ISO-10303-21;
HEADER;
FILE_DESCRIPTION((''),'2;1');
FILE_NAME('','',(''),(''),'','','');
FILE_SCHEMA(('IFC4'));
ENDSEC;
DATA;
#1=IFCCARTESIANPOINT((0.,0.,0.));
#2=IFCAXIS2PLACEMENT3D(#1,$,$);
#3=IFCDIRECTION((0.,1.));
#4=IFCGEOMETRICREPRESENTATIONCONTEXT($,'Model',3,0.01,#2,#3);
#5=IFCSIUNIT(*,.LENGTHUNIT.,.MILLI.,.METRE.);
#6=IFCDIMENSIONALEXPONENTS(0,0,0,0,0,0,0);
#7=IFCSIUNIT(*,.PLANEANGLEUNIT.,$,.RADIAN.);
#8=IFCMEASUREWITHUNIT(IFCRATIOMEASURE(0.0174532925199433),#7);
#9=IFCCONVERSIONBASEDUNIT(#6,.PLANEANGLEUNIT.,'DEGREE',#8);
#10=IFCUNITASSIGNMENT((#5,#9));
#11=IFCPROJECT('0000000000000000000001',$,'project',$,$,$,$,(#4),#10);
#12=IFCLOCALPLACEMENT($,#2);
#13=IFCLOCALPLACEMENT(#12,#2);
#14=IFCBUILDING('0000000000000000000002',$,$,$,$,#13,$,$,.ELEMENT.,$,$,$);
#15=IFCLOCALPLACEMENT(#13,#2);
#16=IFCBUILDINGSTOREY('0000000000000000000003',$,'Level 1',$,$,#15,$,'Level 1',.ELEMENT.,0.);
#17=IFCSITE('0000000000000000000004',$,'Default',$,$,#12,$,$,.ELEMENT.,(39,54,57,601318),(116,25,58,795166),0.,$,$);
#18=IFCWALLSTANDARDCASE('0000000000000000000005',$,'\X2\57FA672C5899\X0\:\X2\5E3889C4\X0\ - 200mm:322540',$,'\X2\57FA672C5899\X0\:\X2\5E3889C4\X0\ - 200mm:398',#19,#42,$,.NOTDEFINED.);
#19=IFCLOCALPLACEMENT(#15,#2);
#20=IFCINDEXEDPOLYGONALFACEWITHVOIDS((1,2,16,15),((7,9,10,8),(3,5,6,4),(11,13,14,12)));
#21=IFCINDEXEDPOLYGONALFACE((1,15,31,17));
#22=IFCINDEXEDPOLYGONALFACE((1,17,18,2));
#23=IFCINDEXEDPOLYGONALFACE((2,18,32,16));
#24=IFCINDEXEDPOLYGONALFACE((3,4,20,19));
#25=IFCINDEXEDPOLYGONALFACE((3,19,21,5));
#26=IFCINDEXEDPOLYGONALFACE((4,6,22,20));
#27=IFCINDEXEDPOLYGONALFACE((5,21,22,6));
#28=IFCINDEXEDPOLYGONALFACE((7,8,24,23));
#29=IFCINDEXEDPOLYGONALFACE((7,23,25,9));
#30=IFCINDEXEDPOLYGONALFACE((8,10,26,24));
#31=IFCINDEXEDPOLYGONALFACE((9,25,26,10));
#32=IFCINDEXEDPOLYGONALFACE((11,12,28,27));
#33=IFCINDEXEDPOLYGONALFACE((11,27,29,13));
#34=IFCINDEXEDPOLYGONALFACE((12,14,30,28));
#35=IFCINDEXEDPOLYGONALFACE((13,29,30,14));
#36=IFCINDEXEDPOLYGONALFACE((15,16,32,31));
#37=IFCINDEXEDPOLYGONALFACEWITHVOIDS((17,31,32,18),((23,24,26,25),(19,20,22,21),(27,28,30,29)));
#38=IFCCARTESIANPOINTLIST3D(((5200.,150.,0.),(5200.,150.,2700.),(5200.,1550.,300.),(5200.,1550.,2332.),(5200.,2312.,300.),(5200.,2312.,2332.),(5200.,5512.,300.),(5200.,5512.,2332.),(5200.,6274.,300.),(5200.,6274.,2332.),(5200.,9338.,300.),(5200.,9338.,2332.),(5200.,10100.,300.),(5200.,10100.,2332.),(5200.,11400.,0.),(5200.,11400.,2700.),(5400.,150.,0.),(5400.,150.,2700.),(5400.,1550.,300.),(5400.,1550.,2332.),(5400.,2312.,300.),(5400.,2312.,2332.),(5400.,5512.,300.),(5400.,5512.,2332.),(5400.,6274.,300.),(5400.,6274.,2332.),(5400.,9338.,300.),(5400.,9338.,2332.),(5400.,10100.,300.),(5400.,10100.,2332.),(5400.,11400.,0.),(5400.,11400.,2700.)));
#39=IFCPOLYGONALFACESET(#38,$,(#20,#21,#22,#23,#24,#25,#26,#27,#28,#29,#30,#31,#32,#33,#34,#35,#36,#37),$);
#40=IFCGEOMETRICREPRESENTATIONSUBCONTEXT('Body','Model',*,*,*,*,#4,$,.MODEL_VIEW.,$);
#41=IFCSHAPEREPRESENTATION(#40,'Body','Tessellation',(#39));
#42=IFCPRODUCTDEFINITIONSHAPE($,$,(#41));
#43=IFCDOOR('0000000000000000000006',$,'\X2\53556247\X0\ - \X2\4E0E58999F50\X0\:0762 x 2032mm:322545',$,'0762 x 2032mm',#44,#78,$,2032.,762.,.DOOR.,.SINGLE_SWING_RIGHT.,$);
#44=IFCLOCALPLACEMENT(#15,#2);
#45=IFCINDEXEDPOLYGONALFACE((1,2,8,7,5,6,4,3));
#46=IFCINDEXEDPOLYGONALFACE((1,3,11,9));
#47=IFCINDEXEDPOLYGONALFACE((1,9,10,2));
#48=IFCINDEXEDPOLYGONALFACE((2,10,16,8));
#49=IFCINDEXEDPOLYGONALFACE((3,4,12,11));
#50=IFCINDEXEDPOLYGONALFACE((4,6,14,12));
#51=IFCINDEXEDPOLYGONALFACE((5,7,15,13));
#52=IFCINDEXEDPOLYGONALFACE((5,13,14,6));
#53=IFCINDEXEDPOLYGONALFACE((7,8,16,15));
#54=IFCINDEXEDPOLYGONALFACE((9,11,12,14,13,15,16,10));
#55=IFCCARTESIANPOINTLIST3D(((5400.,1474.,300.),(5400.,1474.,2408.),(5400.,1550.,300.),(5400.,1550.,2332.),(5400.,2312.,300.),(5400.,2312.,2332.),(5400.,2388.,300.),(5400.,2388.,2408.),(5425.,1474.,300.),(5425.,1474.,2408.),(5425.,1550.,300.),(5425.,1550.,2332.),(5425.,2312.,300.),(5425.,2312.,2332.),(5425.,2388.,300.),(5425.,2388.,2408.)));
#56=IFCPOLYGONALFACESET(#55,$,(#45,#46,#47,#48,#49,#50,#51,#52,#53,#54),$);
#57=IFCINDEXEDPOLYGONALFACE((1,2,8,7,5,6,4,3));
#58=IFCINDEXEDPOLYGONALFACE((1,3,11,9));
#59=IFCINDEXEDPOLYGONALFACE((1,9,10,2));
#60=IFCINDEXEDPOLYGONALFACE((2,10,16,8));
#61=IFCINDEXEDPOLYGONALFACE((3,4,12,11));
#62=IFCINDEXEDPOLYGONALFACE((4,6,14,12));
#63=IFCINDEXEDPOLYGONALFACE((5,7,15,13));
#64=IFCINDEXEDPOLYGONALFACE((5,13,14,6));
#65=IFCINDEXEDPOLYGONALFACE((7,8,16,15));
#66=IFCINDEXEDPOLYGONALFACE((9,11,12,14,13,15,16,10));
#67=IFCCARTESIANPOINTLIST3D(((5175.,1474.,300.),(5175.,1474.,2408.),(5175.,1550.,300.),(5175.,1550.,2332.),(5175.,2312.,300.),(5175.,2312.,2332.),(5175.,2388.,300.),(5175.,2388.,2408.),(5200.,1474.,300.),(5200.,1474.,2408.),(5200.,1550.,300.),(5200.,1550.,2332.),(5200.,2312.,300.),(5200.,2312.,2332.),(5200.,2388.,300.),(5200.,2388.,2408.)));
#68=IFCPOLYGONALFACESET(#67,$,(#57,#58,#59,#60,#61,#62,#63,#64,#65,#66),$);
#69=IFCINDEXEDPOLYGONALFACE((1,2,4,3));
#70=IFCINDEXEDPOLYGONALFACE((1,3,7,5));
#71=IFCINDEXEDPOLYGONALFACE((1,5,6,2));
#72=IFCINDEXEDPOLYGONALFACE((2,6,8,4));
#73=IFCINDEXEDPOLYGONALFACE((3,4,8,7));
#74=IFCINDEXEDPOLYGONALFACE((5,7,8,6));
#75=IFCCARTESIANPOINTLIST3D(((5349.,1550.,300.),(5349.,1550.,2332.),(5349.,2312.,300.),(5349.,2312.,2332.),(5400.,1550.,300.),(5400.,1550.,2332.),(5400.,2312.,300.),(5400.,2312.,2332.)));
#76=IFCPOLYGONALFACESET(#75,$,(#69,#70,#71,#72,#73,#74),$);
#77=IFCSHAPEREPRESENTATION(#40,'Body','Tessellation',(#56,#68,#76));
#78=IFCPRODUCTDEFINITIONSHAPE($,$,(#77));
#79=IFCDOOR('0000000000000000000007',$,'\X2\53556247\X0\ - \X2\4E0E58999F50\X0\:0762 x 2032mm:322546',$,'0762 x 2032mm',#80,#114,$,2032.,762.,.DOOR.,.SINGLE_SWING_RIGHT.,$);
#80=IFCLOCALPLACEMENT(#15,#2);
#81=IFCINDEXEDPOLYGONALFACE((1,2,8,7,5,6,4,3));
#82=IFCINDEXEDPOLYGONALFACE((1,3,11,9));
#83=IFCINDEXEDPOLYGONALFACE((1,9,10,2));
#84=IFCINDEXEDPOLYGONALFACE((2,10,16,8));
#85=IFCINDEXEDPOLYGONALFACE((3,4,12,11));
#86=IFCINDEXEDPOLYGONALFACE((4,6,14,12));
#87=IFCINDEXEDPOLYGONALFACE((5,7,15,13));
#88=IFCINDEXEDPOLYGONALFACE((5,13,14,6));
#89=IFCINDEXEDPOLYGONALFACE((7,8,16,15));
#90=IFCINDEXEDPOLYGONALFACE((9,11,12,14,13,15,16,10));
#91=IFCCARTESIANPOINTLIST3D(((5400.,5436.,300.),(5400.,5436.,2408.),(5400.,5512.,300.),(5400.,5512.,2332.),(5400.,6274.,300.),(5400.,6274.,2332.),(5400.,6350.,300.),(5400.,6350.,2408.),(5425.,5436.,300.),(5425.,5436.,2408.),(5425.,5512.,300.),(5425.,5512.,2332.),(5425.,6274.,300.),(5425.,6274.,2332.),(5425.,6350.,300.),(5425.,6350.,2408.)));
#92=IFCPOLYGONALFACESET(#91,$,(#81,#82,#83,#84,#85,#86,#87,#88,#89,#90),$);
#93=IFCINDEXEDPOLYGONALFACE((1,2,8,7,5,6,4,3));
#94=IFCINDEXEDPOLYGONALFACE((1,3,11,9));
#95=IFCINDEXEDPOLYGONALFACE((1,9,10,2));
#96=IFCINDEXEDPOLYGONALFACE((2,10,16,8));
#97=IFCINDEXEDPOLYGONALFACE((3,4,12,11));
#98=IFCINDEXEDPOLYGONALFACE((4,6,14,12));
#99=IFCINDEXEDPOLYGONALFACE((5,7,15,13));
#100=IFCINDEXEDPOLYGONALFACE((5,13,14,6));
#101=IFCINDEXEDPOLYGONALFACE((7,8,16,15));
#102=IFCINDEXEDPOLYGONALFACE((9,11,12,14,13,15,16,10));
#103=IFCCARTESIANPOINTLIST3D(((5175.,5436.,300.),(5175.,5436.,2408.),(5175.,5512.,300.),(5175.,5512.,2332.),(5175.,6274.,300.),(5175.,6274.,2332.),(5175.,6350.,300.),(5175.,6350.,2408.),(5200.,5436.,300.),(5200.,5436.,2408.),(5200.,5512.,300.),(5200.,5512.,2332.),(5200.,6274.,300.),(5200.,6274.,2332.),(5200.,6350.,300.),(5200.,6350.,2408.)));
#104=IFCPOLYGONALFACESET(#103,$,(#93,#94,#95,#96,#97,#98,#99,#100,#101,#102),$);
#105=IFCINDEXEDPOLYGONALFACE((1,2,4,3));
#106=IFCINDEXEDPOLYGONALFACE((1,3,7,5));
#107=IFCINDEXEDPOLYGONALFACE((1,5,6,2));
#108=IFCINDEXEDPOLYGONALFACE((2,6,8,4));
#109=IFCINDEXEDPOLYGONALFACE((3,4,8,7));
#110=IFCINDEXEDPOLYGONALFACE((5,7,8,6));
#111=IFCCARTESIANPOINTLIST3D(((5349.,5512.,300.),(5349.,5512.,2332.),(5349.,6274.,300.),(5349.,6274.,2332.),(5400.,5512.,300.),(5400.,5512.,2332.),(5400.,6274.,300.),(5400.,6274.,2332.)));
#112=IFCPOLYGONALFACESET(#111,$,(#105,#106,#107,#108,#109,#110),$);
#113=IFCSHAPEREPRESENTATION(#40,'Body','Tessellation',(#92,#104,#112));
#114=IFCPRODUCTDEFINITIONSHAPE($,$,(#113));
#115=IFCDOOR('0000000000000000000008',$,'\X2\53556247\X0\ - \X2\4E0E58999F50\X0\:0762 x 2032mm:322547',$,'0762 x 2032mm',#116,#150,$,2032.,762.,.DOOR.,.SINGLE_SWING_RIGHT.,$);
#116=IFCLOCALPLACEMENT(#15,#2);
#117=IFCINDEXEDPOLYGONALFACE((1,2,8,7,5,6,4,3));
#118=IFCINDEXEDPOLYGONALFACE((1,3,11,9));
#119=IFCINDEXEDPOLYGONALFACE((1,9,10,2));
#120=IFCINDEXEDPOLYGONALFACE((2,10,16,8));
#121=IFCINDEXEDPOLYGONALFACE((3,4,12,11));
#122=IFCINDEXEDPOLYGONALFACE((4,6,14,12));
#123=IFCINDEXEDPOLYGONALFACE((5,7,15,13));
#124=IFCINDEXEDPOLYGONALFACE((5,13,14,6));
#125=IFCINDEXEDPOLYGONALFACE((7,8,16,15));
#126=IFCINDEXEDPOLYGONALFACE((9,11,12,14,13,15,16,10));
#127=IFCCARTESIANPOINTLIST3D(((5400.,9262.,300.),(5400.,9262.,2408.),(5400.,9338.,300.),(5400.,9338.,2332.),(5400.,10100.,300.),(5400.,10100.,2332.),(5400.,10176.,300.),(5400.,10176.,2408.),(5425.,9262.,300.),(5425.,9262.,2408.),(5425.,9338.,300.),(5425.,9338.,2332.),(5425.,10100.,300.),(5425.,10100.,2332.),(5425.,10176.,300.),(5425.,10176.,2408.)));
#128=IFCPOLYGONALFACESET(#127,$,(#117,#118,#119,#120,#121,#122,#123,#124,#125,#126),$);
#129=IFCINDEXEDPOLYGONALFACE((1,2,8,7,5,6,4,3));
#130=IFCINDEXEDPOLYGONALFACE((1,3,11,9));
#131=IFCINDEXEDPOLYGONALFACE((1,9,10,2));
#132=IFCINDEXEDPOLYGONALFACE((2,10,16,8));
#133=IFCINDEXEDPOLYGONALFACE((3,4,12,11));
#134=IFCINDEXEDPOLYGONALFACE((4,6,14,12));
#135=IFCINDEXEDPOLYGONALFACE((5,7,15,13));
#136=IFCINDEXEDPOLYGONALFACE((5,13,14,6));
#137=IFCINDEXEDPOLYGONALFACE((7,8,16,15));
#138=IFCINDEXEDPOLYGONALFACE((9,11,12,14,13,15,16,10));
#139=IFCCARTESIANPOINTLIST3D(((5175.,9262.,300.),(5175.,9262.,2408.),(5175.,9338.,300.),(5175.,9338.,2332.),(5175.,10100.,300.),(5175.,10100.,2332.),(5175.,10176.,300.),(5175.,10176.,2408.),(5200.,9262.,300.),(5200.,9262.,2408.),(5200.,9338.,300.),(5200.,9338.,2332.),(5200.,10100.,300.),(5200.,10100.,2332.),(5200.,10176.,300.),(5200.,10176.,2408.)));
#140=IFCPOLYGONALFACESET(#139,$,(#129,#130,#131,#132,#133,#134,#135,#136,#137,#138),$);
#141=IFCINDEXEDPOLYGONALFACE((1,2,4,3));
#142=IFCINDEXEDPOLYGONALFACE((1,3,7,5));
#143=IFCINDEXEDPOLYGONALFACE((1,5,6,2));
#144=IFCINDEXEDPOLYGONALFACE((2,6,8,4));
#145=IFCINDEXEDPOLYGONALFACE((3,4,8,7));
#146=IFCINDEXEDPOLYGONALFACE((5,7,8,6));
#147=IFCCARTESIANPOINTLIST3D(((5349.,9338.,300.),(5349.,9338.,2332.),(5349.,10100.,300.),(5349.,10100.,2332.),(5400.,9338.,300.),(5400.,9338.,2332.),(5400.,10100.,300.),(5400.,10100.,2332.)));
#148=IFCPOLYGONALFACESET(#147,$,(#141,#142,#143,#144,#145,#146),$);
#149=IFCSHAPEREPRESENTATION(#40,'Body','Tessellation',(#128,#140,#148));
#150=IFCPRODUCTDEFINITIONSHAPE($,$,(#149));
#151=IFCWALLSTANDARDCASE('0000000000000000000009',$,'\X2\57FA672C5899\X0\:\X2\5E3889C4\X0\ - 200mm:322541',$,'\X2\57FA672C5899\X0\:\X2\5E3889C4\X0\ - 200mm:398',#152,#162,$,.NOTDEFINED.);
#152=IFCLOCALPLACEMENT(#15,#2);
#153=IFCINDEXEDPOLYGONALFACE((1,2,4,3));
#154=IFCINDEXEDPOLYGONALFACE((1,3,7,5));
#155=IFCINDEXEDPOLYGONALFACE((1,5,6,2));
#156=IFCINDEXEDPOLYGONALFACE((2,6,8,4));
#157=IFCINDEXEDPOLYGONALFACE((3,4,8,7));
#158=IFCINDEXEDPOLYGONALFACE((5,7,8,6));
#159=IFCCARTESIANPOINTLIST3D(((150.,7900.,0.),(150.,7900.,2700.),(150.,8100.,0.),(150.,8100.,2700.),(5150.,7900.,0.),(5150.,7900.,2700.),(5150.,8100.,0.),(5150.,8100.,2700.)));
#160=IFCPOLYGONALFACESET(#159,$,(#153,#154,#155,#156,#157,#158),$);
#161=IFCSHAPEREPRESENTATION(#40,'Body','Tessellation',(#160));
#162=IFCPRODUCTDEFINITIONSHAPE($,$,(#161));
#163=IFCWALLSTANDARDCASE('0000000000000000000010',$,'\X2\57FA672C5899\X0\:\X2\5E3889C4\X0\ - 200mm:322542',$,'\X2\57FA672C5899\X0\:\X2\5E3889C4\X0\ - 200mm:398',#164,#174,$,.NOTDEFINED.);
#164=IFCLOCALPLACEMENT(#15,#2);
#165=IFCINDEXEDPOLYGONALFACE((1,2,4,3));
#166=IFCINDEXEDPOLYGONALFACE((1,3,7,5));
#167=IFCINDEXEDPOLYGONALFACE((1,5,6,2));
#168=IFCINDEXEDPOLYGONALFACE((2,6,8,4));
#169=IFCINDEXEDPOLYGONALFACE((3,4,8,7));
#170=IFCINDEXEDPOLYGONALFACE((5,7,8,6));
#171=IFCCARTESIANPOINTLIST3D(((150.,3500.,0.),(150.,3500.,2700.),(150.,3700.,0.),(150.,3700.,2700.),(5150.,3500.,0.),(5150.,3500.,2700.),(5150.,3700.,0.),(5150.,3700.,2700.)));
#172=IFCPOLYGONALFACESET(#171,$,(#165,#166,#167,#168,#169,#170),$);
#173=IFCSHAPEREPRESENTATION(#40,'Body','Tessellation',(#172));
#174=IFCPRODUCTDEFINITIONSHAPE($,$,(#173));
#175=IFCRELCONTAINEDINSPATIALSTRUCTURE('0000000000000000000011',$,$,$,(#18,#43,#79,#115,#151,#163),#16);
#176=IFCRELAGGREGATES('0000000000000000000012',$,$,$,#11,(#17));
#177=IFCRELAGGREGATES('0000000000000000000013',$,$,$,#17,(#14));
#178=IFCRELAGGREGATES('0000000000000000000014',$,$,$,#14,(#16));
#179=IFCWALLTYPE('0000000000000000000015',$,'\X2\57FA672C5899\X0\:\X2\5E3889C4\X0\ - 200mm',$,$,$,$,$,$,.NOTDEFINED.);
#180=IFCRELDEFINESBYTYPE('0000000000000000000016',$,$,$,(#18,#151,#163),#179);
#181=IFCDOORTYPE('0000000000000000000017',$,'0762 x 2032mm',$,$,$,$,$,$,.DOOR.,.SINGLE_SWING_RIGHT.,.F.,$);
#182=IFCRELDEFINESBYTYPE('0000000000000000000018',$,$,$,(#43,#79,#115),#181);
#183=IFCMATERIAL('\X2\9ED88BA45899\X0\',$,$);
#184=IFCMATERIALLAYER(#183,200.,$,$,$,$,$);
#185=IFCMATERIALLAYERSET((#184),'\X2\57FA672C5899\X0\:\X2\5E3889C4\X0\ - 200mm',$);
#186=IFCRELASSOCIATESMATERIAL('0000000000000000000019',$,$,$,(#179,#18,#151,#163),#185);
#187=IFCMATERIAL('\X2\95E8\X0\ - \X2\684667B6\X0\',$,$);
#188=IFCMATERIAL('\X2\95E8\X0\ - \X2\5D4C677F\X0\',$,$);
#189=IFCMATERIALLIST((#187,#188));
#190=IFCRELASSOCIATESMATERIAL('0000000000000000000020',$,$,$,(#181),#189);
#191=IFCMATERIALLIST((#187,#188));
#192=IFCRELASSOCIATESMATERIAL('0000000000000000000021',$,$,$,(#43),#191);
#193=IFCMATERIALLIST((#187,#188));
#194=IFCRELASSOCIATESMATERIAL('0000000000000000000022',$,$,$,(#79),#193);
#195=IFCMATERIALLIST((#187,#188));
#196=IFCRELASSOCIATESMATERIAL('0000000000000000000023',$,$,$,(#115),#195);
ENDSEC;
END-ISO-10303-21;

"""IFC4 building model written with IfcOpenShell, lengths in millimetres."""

from ifc_helpers import new_model, entity, si_unit, converted_unit, direction, frame, frame_2d, origin, origin_2d_with_axis, place, context, subcontext, project, spatial, polyline, rectangle, outline, extrude, clip, bounded_halfspace, source, transform, mapped, material, material_list, layer, layer_set, layer_usage, type_object, type_shapes, element, fill, save


model = new_model("IFC4")

# Units and contexts
model_context = context("Model", 3, precision=0.01, world=origin(), true_north=direction((0.0, 1.0)))
body_context = subcontext(model_context, "Body", "Model", "MODEL_VIEW")
ifc_project = project(units=[si_unit("LENGTHUNIT", "METRE", prefix="MILLI"), converted_unit("PLANEANGLEUNIT", "DEGREE", entity("IfcRatioMeasure", 0.0174532925199433), si_unit("PLANEANGLEUNIT", "RADIAN"), dimensions=[0, 0, 0, 0, 0, 0, 0])], contexts=[model_context])

# Site, building, storey
site_placement = place(None, origin())
site = spatial("IfcSite", under=ifc_project, at=site_placement, Name="Default", CompositionType="ELEMENT", RefLatitude=(39, 54, 57, 601318), RefLongitude=(116, 25, 58, 795166), RefElevation=0.0)
building_placement = place(site_placement, origin())
building = spatial("IfcBuilding", under=site, at=building_placement, CompositionType="ELEMENT")
storey_placement = place(building_placement, origin())
storey = spatial("IfcBuildingStorey", under=building, at=storey_placement, Name="Level 1", LongName="Level 1", CompositionType="ELEMENT", Elevation=0.0)

# Shared definitions
ifc_material_1 = material(Name="默认墙")
ifc_layer_1 = layer(ifc_material_1, 200.0)
ifc_layer_set_1 = layer_set([ifc_layer_1], Name="基本墙:常规 - 200mm")
wall_type = type_object("IfcWallType", Name="基本墙:常规 - 200mm", PredefinedType="NOTDEFINED", material=ifc_layer_set_1)

# Wall, openings, doors
ifc_layer_usage_1 = layer_usage(ifc_layer_set_1, "AXIS2", "NEGATIVE", 100.0)
wall_1_placement = place(storey_placement, frame((5300.0, 11400.0, 0.0), z_axis=(0.0, 0.0, 1.0), x_axis=(0.0, -1.0, 0.0)))
wall_1 = element("IfcWallStandardCase", 1, at=wall_1_placement, inside=storey, type_object=wall_type, material=ifc_layer_usage_1, Name="基本墙:常规 - 200mm:322540", ObjectType="基本墙:常规 - 200mm:398", PredefinedType="NOTDEFINED", context=body_context, shape_type="Clipping", body=[
    clip(extrude(rectangle(XDim=11250.0, YDim=200.0, at=frame_2d((5625.0, 0.0), x_axis=(-1.0, 0.0))), origin(), (0.0, 0.0, 1.0), 2700.0), bounded_halfspace(frame((0.0, -100.0, 2700.0), z_axis=(0.0, 0.0, -1.0), x_axis=(-1.0, 0.0, 0.0)), True, frame((0.0, -100.0, 2700.0)), polyline([(0.0, 0.0), (11250.0, 0.0), (11250.0, 200.0), (0.0, 200.0), (0.0, 0.0)]))),
])
opening_1_placement = place(wall_1_placement, frame((9088.0, -100.0, 300.0)))
opening_1 = element("IfcOpeningElement", 2, at=opening_1_placement, cuts=wall_1, ObjectType="Opening", PredefinedType="OPENING", context=body_context, shape_type="SweptSolid", body=[
    extrude(rectangle(XDim=762.0, YDim=2032.0, at=frame_2d((1016.0, 381.0), x_axis=(0.0, 1.0))), frame((0.0, 0.0, 0.0), z_axis=(0.0, 1.0, 0.0), x_axis=(0.0, 0.0, 1.0)), (0.0, 0.0, 1.0), 200.0),
])
opening_2_placement = place(wall_1_placement, frame((5126.0, -100.0, 300.0)))
opening_2 = element("IfcOpeningElement", 3, at=opening_2_placement, cuts=wall_1, ObjectType="Opening", PredefinedType="OPENING", context=body_context, shape_type="SweptSolid", body=[
    extrude(rectangle(XDim=762.0, YDim=2032.0, at=frame_2d((1016.0, 381.0), x_axis=(0.0, 1.0))), frame((0.0, 0.0, 0.0), z_axis=(0.0, 1.0, 0.0), x_axis=(0.0, 0.0, 1.0)), (0.0, 0.0, 1.0), 200.0),
])
opening_3_placement = place(wall_1_placement, frame((1300.0, -100.0, 300.0)))
opening_3 = element("IfcOpeningElement", 4, at=opening_3_placement, cuts=wall_1, ObjectType="Opening", PredefinedType="OPENING", context=body_context, shape_type="SweptSolid", body=[
    extrude(rectangle(XDim=762.0, YDim=2032.0, at=frame_2d((1016.0, 381.0), x_axis=(0.0, 1.0))), frame((0.0, 0.0, 0.0), z_axis=(0.0, 1.0, 0.0), x_axis=(0.0, 0.0, 1.0)), (0.0, 0.0, 1.0), 200.0),
])
ifc_material_2 = material(Name="门 - 框架")
ifc_material_3 = material(Name="门 - 嵌板")
ifc_material_list_1 = material_list([ifc_material_2, ifc_material_3])
ifc_material_list_2 = material_list([ifc_material_2, ifc_material_3])
door_type_1 = type_object("IfcDoorType", Name="0762 x 2032mm", OperationType="SINGLE_SWING_RIGHT", ParameterTakesPrecedence=False, PredefinedType="DOOR", material=ifc_material_list_2)
shared_shape_1 = source(origin(), body_context, "Body", "SweptSolid", [
    extrude(outline(polyline([(-457.0, -1073.0), (457.0, -1073.0), (457.0, 1035.0), (381.0, 1035.0), (381.0, -997.0), (-381.0, -997.0), (-381.0, 1035.0), (-457.0, 1035.0), (-457.0, -1073.0)])), frame((381.0, 200.0, 1035.0), z_axis=(0.0, 1.0, 0.0), x_axis=(1.0, 0.0, 0.0)), (0.0, 0.0, 1.0), 25.0),
    extrude(outline(polyline([(-1073.0, -457.0), (1035.0, -457.0), (1035.0, -381.0), (-997.0, -381.0), (-997.0, 381.0), (1035.0, 381.0), (1035.0, 457.0), (-1073.0, 457.0), (-1073.0, -457.0)])), frame((381.0, -25.0, 1035.0), z_axis=(0.0, 1.0, 0.0), x_axis=(0.0, 0.0, -1.0)), (0.0, 0.0, 1.0), 25.0),
    extrude(rectangle(XDim=51.0, YDim=762.0, at=origin_2d_with_axis()), frame((381.0, 174.5, 0.0), z_axis=(0.0, 0.0, 1.0), x_axis=(0.0, 1.0, 0.0)), (0.0, 0.0, 1.0), 2032.0),
])
type_shapes(door_type_1, [shared_shape_1])
door_1_placement = place(opening_1_placement, origin())
door_1 = element("IfcDoor", 5, at=door_1_placement, inside=storey, type_object=door_type_1, material=ifc_material_list_1, Name="单扇 - 与墙齐:0762 x 2032mm:322545", ObjectType="0762 x 2032mm", OperationType="SINGLE_SWING_RIGHT", OverallHeight=2032.0, OverallWidth=762.0, PredefinedType="DOOR", context=body_context, shape_type="MappedRepresentation", body=[
    mapped(shared_shape_1, transform((0.0, 0.0, 0.0), scale=1.0)),
])
fill(opening_1, door_1)
ifc_material_list_3 = material_list([ifc_material_2, ifc_material_3])
door_2_placement = place(opening_2_placement, origin())
door_2 = element("IfcDoor", 6, at=door_2_placement, inside=storey, type_object=door_type_1, material=ifc_material_list_3, Name="单扇 - 与墙齐:0762 x 2032mm:322546", ObjectType="0762 x 2032mm", OperationType="SINGLE_SWING_RIGHT", OverallHeight=2032.0, OverallWidth=762.0, PredefinedType="DOOR", context=body_context, shape_type="MappedRepresentation", body=[
    mapped(shared_shape_1, transform((0.0, 0.0, 0.0), scale=1.0)),
])
fill(opening_2, door_2)
ifc_material_list_4 = material_list([ifc_material_2, ifc_material_3])
door_3_placement = place(opening_3_placement, origin())
door_3 = element("IfcDoor", 7, at=door_3_placement, inside=storey, type_object=door_type_1, material=ifc_material_list_4, Name="单扇 - 与墙齐:0762 x 2032mm:322547", ObjectType="0762 x 2032mm", OperationType="SINGLE_SWING_RIGHT", OverallHeight=2032.0, OverallWidth=762.0, PredefinedType="DOOR", context=body_context, shape_type="MappedRepresentation", body=[
    mapped(shared_shape_1, transform((0.0, 0.0, 0.0), scale=1.0)),
])
fill(opening_3, door_3)

# Walls
ifc_layer_usage_2 = layer_usage(ifc_layer_set_1, "AXIS2", "NEGATIVE", 100.0)
wall_2_placement = place(storey_placement, frame((150.0, 8000.0, 0.0)))
element("IfcWallStandardCase", 8, at=wall_2_placement, inside=storey, type_object=wall_type, material=ifc_layer_usage_2, Name="基本墙:常规 - 200mm:322541", ObjectType="基本墙:常规 - 200mm:398", PredefinedType="NOTDEFINED", context=body_context, shape_type="Clipping", body=[
    clip(extrude(rectangle(XDim=5000.0, YDim=200.0, at=frame_2d((2500.0, 0.0), x_axis=(-1.0, 0.0))), origin(), (0.0, 0.0, 1.0), 2700.0), bounded_halfspace(frame((0.0, -100.0, 2700.0), z_axis=(0.0, 0.0, -1.0), x_axis=(0.0, 1.0, 0.0)), True, frame((0.0, -100.0, 2700.0)), polyline([(0.0, 0.0), (5000.0, 0.0), (5000.0, 200.0), (0.0, 200.0), (0.0, 0.0)]))),
])
ifc_layer_usage_3 = layer_usage(ifc_layer_set_1, "AXIS2", "NEGATIVE", 100.0)
wall_3_placement = place(storey_placement, frame((150.0, 3600.0, 0.0)))
element("IfcWallStandardCase", 9, at=wall_3_placement, inside=storey, type_object=wall_type, material=ifc_layer_usage_3, Name="基本墙:常规 - 200mm:322542", ObjectType="基本墙:常规 - 200mm:398", PredefinedType="NOTDEFINED", context=body_context, shape_type="Clipping", body=[
    clip(extrude(rectangle(XDim=5000.0, YDim=200.0, at=frame_2d((2500.0, 0.0), x_axis=(-1.0, 0.0))), origin(), (0.0, 0.0, 1.0), 2700.0), bounded_halfspace(frame((0.0, -100.0, 2700.0), z_axis=(0.0, 0.0, -1.0), x_axis=(0.0, 1.0, 0.0)), True, frame((0.0, -100.0, 2700.0)), polyline([(0.0, 0.0), (5000.0, 0.0), (5000.0, 200.0), (0.0, 200.0), (0.0, 0.0)]))),
])

save(model, "model.ifc")
